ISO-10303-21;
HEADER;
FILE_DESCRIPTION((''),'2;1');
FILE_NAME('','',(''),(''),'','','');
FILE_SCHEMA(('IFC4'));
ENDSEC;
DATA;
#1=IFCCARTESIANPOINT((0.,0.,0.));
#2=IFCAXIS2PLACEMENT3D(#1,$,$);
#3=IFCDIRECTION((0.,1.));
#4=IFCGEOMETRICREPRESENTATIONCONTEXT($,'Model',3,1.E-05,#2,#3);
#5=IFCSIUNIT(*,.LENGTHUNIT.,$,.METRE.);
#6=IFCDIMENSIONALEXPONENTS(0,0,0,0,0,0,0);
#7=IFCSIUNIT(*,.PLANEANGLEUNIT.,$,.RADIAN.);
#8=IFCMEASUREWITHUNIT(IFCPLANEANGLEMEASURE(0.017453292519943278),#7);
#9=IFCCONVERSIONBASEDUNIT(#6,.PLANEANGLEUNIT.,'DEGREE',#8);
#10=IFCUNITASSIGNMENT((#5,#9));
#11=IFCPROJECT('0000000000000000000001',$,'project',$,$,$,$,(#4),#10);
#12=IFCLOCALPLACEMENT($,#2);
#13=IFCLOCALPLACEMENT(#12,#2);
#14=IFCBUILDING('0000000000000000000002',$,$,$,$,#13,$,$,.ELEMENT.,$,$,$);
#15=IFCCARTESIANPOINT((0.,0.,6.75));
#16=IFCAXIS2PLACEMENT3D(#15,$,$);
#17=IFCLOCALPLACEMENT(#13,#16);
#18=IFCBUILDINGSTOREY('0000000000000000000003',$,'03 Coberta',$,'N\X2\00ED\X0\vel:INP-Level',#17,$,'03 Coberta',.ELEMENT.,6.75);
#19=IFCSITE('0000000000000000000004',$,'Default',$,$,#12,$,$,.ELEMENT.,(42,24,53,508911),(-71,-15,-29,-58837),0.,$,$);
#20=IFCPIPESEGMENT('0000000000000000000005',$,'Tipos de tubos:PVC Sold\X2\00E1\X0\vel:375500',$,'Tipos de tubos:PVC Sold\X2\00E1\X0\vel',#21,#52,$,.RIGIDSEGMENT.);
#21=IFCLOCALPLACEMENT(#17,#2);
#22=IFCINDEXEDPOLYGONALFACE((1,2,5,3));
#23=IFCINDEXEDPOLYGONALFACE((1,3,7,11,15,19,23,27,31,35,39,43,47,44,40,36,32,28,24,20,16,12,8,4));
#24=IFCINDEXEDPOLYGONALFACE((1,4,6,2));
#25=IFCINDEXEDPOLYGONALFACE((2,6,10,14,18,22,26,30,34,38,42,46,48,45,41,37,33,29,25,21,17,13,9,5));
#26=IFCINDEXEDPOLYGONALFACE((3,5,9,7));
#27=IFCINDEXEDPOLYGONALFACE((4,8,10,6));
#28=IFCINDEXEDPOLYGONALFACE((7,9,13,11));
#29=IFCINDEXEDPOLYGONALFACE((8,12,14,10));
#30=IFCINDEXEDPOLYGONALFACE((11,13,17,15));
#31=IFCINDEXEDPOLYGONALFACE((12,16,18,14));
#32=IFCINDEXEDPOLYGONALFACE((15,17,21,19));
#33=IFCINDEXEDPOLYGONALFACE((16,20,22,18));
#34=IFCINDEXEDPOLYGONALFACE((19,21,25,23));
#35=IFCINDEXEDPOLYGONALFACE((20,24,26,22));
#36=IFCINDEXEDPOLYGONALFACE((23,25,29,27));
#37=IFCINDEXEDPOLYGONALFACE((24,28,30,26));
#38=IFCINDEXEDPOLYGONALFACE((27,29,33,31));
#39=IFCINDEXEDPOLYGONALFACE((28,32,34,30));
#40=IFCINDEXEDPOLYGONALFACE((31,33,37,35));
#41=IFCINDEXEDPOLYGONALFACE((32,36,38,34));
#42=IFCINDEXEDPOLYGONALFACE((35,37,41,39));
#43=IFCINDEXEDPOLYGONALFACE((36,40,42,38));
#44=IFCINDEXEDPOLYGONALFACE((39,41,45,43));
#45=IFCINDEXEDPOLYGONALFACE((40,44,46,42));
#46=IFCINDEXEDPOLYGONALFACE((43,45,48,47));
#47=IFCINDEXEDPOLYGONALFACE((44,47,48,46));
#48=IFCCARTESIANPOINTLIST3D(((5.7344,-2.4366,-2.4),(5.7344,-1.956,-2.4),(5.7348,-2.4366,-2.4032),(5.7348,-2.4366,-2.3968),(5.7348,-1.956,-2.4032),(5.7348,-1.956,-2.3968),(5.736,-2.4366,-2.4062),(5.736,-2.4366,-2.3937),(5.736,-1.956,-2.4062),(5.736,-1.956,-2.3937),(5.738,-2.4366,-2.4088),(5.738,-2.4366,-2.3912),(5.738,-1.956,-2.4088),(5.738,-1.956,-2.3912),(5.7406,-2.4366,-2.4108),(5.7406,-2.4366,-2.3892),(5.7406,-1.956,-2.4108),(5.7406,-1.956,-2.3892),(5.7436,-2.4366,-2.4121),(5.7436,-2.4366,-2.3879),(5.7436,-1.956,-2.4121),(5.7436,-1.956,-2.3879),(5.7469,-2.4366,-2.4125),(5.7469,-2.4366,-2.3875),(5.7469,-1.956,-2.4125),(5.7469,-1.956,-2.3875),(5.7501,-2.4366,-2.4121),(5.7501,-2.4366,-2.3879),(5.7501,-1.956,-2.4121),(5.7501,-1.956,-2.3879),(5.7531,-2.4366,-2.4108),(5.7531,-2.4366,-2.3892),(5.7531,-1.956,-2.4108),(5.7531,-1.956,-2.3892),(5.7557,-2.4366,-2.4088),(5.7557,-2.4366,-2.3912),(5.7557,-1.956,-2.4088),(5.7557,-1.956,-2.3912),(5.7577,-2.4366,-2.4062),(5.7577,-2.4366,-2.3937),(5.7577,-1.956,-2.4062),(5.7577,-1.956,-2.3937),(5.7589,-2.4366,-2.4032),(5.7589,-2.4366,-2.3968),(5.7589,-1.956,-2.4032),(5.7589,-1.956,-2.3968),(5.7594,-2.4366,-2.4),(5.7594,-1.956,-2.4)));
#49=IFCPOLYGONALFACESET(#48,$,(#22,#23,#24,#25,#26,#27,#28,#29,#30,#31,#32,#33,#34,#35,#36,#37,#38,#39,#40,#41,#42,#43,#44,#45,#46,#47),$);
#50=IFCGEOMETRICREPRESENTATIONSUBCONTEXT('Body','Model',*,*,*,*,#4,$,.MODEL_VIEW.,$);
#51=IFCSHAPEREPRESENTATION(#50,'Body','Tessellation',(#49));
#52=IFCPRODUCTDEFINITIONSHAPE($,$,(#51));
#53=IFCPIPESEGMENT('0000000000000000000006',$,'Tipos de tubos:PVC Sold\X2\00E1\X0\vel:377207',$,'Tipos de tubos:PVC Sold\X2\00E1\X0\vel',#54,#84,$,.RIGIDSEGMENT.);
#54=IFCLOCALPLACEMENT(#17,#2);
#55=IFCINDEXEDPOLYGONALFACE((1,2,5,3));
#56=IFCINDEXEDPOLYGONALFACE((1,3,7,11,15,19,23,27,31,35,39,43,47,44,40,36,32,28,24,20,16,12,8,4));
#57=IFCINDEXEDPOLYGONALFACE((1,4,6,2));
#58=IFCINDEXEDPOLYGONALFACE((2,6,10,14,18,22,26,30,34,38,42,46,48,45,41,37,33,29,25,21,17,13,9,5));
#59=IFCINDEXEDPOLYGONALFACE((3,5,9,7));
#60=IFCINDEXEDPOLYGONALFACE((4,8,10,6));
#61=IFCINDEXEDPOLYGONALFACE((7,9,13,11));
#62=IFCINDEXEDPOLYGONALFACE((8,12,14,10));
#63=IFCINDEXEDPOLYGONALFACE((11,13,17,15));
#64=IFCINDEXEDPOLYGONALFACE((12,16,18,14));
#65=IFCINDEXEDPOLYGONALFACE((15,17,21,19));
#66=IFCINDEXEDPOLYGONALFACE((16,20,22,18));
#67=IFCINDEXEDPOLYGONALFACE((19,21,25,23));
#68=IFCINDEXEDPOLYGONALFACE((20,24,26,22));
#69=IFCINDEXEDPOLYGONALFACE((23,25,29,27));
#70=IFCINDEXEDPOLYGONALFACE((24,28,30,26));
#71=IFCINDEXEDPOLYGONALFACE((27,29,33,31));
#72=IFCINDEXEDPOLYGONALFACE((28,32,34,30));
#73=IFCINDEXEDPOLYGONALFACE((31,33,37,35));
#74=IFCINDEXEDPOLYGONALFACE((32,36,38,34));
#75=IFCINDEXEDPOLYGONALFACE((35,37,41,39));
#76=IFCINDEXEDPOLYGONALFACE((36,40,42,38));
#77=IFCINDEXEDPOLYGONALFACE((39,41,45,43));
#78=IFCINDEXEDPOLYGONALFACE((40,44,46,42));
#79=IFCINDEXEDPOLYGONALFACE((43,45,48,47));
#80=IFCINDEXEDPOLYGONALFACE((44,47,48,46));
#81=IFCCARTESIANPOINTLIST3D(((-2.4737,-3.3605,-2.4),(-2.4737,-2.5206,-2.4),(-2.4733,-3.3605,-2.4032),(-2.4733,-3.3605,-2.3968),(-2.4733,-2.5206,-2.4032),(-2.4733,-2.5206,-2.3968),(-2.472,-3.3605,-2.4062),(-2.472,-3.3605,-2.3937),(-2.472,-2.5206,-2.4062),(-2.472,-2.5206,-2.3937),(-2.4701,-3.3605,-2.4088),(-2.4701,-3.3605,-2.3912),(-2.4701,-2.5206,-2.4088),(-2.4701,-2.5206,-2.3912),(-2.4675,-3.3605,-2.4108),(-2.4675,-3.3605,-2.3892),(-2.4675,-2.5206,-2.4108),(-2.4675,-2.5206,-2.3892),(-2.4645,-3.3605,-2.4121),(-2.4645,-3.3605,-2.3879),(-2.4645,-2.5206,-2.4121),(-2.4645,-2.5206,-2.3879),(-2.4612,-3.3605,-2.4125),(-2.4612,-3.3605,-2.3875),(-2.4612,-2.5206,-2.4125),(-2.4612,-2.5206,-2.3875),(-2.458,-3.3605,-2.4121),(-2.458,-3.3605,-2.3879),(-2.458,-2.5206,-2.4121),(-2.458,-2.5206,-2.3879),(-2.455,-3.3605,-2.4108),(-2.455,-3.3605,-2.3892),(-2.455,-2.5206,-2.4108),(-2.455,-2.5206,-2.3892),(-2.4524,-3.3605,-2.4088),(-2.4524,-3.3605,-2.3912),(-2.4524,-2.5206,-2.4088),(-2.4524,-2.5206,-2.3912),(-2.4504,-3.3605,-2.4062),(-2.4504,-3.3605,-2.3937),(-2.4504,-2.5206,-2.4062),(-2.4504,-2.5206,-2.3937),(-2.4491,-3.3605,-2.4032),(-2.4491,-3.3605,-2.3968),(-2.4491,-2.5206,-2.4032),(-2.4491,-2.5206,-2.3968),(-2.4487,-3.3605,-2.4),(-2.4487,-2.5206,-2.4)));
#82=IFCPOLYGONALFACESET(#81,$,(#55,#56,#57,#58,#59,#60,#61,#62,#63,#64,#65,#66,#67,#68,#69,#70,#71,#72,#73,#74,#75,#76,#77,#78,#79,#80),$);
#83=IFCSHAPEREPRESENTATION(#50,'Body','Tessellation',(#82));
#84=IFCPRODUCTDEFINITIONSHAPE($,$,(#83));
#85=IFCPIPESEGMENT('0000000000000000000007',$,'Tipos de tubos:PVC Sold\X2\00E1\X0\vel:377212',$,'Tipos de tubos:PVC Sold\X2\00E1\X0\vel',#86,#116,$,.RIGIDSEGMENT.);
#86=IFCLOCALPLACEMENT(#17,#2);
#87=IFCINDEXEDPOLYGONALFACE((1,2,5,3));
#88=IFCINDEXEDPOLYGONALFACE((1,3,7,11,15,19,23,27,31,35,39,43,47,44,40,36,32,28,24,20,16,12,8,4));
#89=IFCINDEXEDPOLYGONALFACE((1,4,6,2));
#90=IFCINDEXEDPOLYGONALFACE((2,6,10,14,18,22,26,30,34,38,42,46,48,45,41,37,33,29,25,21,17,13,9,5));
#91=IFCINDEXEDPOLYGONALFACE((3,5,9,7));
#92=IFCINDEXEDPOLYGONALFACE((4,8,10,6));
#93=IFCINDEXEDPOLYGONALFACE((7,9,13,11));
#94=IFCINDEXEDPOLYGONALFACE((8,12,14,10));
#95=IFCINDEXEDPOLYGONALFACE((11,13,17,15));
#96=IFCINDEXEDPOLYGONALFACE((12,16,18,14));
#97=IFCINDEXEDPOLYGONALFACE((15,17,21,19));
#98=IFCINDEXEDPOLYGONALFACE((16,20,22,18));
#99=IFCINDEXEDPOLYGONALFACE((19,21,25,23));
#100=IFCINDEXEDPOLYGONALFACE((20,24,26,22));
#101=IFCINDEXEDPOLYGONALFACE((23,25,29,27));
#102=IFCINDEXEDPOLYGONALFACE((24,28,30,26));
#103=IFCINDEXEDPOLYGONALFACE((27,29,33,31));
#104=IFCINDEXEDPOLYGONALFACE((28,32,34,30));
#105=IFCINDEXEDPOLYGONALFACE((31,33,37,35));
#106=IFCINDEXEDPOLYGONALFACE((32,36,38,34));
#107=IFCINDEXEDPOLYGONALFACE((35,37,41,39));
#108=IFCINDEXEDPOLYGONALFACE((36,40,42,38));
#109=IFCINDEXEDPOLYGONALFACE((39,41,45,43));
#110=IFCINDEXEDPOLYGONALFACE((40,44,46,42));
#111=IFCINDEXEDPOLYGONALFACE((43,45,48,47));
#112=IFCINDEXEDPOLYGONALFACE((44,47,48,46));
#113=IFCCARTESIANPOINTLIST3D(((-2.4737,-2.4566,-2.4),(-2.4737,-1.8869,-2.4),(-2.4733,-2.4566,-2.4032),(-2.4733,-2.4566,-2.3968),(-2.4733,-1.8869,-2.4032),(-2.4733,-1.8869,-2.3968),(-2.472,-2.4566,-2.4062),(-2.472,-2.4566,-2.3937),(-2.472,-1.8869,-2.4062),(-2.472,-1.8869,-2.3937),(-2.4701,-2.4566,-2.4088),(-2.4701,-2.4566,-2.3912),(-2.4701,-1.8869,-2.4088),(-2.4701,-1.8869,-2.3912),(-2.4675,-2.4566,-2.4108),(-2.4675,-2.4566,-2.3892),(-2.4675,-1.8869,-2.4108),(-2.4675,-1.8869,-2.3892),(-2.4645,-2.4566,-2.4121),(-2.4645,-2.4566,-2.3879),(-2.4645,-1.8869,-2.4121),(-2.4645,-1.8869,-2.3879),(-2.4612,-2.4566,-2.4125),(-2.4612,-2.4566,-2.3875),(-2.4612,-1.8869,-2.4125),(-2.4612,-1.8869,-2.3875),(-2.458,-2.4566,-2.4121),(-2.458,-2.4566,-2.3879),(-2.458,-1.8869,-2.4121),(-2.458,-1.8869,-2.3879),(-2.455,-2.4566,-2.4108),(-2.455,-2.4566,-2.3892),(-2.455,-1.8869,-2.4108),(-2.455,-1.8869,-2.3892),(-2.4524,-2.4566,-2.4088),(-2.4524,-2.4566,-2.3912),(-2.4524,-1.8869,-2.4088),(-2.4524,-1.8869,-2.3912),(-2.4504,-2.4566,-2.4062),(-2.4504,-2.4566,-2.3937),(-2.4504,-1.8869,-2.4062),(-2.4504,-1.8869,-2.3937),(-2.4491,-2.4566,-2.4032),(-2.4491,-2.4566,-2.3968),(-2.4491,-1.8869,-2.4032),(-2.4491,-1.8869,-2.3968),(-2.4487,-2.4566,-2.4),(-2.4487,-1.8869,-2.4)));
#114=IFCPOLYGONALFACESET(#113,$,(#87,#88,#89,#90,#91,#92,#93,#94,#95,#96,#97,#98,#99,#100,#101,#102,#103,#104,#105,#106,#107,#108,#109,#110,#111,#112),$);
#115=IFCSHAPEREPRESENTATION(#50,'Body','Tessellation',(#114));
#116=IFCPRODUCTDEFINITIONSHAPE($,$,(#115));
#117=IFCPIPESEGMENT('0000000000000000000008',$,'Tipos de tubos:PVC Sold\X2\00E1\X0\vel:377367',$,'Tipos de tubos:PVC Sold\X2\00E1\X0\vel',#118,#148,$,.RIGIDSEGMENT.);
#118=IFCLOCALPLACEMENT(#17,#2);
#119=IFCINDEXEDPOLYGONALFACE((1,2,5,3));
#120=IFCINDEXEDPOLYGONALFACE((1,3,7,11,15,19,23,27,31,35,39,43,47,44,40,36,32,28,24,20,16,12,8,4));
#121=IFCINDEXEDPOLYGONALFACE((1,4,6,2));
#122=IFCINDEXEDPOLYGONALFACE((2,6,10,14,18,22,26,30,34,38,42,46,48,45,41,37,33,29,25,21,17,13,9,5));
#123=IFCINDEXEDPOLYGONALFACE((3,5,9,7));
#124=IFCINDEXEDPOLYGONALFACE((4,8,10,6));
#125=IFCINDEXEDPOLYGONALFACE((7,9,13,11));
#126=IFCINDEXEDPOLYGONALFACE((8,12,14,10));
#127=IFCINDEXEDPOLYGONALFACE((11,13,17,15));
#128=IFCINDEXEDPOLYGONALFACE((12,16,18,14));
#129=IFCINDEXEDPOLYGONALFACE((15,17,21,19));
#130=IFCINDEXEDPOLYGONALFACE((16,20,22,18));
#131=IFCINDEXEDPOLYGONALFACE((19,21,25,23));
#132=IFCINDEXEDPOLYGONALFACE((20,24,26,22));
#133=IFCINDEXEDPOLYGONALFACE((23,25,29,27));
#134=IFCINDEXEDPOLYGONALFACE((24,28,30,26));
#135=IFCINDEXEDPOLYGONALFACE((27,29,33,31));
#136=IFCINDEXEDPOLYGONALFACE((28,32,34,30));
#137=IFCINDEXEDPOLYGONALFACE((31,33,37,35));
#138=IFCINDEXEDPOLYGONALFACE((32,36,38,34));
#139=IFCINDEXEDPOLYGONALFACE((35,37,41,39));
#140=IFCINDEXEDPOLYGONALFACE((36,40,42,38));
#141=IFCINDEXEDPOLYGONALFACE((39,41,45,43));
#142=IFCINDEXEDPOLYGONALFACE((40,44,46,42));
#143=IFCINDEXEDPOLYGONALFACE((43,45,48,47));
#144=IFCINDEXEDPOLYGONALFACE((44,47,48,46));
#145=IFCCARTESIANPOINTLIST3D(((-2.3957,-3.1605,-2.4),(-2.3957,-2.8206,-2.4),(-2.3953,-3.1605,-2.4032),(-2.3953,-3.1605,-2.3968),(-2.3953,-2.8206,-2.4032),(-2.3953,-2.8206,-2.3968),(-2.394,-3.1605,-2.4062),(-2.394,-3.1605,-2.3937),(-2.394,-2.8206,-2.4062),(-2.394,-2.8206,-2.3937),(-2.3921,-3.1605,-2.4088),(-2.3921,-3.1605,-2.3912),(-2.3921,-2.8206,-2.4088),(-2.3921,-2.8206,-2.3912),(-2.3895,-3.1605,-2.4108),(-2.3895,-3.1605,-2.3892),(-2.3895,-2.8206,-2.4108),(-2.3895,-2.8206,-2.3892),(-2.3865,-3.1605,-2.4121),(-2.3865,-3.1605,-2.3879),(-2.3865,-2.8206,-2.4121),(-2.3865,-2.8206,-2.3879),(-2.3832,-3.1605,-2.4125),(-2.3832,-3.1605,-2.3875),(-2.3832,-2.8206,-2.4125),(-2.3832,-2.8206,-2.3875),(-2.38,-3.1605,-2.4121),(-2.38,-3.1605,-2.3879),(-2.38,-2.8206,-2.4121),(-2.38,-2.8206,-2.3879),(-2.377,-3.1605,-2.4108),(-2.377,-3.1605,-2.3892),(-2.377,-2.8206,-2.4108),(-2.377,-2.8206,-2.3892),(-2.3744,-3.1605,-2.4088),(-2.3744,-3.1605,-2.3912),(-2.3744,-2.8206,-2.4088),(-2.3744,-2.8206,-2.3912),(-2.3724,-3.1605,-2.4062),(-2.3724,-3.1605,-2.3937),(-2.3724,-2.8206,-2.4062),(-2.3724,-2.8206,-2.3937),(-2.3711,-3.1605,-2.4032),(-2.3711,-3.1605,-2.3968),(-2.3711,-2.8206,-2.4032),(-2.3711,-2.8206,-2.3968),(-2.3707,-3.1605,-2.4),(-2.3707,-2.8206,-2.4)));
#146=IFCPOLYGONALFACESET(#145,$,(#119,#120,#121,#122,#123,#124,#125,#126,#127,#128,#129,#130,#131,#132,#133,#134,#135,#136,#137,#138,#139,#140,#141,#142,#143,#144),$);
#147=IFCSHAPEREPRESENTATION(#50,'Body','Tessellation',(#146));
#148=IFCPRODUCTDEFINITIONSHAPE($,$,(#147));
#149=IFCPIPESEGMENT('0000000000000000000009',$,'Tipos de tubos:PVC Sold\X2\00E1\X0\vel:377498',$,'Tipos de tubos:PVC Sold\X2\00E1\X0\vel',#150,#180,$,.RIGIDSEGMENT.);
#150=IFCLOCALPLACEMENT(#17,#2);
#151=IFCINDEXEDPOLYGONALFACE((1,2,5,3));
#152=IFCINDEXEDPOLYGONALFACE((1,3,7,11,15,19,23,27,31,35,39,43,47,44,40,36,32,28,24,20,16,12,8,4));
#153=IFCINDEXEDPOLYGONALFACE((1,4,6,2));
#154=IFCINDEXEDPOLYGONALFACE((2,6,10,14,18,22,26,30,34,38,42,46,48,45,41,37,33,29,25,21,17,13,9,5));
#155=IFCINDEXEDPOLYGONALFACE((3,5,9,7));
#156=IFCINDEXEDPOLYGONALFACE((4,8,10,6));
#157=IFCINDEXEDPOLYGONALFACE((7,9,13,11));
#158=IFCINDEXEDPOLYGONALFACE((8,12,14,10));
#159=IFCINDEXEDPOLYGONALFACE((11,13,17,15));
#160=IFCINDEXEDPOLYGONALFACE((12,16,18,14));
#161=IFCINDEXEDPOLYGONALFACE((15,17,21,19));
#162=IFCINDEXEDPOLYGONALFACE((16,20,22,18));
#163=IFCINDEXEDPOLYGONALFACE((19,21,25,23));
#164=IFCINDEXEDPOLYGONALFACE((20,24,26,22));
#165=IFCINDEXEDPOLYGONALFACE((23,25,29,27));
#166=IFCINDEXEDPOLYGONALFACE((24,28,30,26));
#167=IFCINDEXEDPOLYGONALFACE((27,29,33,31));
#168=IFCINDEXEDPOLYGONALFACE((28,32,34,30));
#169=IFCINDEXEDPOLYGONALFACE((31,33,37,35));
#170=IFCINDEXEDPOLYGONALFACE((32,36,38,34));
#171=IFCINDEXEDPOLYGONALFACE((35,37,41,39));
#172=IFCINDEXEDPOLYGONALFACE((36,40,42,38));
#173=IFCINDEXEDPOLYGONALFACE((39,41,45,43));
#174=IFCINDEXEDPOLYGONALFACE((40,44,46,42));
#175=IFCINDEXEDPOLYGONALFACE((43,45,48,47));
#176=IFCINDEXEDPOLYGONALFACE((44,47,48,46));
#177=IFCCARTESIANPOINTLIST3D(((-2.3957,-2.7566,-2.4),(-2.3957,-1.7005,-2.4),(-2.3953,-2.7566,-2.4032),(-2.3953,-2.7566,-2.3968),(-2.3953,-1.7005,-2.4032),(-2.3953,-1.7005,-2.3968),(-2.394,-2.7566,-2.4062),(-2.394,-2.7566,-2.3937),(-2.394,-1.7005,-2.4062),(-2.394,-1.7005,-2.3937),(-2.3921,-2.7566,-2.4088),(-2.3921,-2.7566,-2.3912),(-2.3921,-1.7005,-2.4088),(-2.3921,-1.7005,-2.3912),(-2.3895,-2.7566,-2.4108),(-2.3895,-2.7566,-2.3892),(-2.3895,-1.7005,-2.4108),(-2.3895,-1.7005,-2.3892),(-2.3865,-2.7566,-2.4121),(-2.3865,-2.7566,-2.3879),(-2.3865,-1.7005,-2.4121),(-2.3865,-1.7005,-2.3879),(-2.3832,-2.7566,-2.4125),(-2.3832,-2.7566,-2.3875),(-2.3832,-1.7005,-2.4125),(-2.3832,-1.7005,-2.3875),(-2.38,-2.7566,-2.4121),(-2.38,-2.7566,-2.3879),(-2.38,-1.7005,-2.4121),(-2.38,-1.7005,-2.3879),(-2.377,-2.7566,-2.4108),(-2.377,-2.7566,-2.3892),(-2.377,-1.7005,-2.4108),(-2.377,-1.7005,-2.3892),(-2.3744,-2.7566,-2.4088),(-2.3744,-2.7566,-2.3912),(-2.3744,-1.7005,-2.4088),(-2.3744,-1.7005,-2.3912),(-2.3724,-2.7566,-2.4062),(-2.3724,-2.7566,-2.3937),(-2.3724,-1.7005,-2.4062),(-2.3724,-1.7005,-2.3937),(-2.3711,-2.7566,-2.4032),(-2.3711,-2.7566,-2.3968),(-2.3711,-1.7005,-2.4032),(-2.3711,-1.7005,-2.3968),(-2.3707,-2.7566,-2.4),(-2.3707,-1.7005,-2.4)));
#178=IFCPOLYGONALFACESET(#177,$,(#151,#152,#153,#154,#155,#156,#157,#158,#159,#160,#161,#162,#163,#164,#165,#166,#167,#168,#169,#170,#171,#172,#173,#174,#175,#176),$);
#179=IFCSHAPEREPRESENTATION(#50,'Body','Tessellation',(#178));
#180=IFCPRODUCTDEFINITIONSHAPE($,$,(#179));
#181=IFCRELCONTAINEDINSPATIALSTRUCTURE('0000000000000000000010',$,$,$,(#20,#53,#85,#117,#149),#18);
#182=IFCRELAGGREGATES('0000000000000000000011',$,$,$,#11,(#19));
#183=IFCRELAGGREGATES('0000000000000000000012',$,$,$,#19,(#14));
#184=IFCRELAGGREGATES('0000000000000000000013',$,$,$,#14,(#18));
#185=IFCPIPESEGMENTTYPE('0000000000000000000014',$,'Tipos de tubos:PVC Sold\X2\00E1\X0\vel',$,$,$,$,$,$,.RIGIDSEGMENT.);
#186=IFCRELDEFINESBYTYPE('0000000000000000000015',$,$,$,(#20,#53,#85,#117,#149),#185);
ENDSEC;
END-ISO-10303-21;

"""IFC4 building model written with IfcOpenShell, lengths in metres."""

from ifc_helpers import new_model, entity, si_unit, converted_unit, direction, frame, origin, place, context, subcontext, project, spatial, arc, indexed_curve, outline, extrude, type_object, element, save


model = new_model("IFC4")

# Units and contexts
model_context = context("Model", 3, precision=1e-05, world=origin(), true_north=direction((0.0, 1.0)))
body_context = subcontext(model_context, "Body", "Model", "MODEL_VIEW")
ifc_project = project(units=[si_unit("LENGTHUNIT", "METRE"), converted_unit("PLANEANGLEUNIT", "DEGREE", entity("IfcPlaneAngleMeasure", 0.017453292519943278), si_unit("PLANEANGLEUNIT", "RADIAN"), dimensions=[0, 0, 0, 0, 0, 0, 0])], contexts=[model_context])

# Site, building, storey
site_placement = place(None, origin())
site = spatial("IfcSite", under=ifc_project, at=site_placement, Name="Default", CompositionType="ELEMENT", RefLatitude=(42, 24, 53, 508911), RefLongitude=(-71, -15, -29, -58837), RefElevation=0.0)
building_placement = place(site_placement, origin())
building = spatial("IfcBuilding", under=site, at=building_placement, CompositionType="ELEMENT")
storey_placement = place(building_placement, frame((0.0, 0.0, 6.75)))
storey = spatial("IfcBuildingStorey", under=building, at=storey_placement, Name="03 Coberta", ObjectType="Nível:INP-Level", LongName="03 Coberta", CompositionType="ELEMENT", Elevation=6.75)

# Pipe segments
pipe_segment_type = type_object("IfcPipeSegmentType", Name="Tipos de tubos:PVC Soldável", PredefinedType="RIGIDSEGMENT")
pipe_segment_1_placement = place(storey_placement, origin())
element("IfcPipeSegment", 1, at=pipe_segment_1_placement, inside=storey, type_object=pipe_segment_type, Name="Tipos de tubos:PVC Soldável:375500", ObjectType="Tipos de tubos:PVC Soldável", PredefinedType="RIGIDSEGMENT", context=body_context, shape_type="SweptSolid", body=[
    extrude(outline(indexed_curve([(0.0125, 0.0), (0.0088, 0.0088), (0.0, 0.0125), (-0.0088, 0.0088), (-0.0125, 0.0), (-0.0088, -0.0088), (0.0, -0.0125), (0.0088, -0.0088)], segments=[arc(1, 2, 3), arc(3, 4, 5), arc(5, 6, 7), arc(7, 8, 1)], self_intersect=False)), frame((5.7469, -2.4366, -2.4), z_axis=(0.0, 1.0, 0.0), x_axis=(-1.0, 0.0, 0.0)), (0.0, 0.0, 1.0), 0.4806),
])
pipe_segment_2_placement = place(storey_placement, origin())
element("IfcPipeSegment", 2, at=pipe_segment_2_placement, inside=storey, type_object=pipe_segment_type, Name="Tipos de tubos:PVC Soldável:377207", ObjectType="Tipos de tubos:PVC Soldável", PredefinedType="RIGIDSEGMENT", context=body_context, shape_type="SweptSolid", body=[
    extrude(outline(indexed_curve([(0.0125, 0.0), (0.0088, 0.0088), (0.0, 0.0125), (-0.0088, 0.0088), (-0.0125, 0.0), (-0.0088, -0.0088), (0.0, -0.0125), (0.0088, -0.0088)], segments=[arc(1, 2, 3), arc(3, 4, 5), arc(5, 6, 7), arc(7, 8, 1)], self_intersect=False)), frame((-2.4612, -3.3605, -2.4), z_axis=(0.0, 1.0, 0.0), x_axis=(-1.0, 0.0, 0.0)), (0.0, 0.0, 1.0), 0.8398),
])
pipe_segment_3_placement = place(storey_placement, origin())
element("IfcPipeSegment", 3, at=pipe_segment_3_placement, inside=storey, type_object=pipe_segment_type, Name="Tipos de tubos:PVC Soldável:377212", ObjectType="Tipos de tubos:PVC Soldável", PredefinedType="RIGIDSEGMENT", context=body_context, shape_type="SweptSolid", body=[
    extrude(outline(indexed_curve([(0.0125, 0.0), (0.0088, 0.0088), (0.0, 0.0125), (-0.0088, 0.0088), (-0.0125, 0.0), (-0.0088, -0.0088), (0.0, -0.0125), (0.0088, -0.0088)], segments=[arc(1, 2, 3), arc(3, 4, 5), arc(5, 6, 7), arc(7, 8, 1)], self_intersect=False)), frame((-2.4612, -2.4566, -2.4), z_axis=(0.0, 1.0, 0.0), x_axis=(1.0, 0.0, 0.0)), (0.0, 0.0, 1.0), 0.5697),
])
pipe_segment_4_placement = place(storey_placement, origin())
element("IfcPipeSegment", 4, at=pipe_segment_4_placement, inside=storey, type_object=pipe_segment_type, Name="Tipos de tubos:PVC Soldável:377367", ObjectType="Tipos de tubos:PVC Soldável", PredefinedType="RIGIDSEGMENT", context=body_context, shape_type="SweptSolid", body=[
    extrude(outline(indexed_curve([(0.0125, 0.0), (0.0088, 0.0088), (0.0, 0.0125), (-0.0088, 0.0088), (-0.0125, 0.0), (-0.0088, -0.0088), (0.0, -0.0125), (0.0088, -0.0088)], segments=[arc(1, 2, 3), arc(3, 4, 5), arc(5, 6, 7), arc(7, 8, 1)], self_intersect=False)), frame((-2.3832, -3.1605, -2.4), z_axis=(0.0, 1.0, 0.0), x_axis=(-1.0, 0.0, 0.0)), (0.0, 0.0, 1.0), 0.3398),
])
pipe_segment_5_placement = place(storey_placement, origin())
element("IfcPipeSegment", 5, at=pipe_segment_5_placement, inside=storey, type_object=pipe_segment_type, Name="Tipos de tubos:PVC Soldável:377498", ObjectType="Tipos de tubos:PVC Soldável", PredefinedType="RIGIDSEGMENT", context=body_context, shape_type="SweptSolid", body=[
    extrude(outline(indexed_curve([(0.0125, 0.0), (0.0088, 0.0088), (0.0, 0.0125), (-0.0088, 0.0088), (-0.0125, 0.0), (-0.0088, -0.0088), (0.0, -0.0125), (0.0088, -0.0088)], segments=[arc(1, 2, 3), arc(3, 4, 5), arc(5, 6, 7), arc(7, 8, 1)], self_intersect=False)), frame((-2.3832, -2.7566, -2.4), z_axis=(0.0, 1.0, 0.0), x_axis=(-1.0, 0.0, 0.0)), (0.0, 0.0, 1.0), 1.0561),
])

save(model, "model.ifc")
